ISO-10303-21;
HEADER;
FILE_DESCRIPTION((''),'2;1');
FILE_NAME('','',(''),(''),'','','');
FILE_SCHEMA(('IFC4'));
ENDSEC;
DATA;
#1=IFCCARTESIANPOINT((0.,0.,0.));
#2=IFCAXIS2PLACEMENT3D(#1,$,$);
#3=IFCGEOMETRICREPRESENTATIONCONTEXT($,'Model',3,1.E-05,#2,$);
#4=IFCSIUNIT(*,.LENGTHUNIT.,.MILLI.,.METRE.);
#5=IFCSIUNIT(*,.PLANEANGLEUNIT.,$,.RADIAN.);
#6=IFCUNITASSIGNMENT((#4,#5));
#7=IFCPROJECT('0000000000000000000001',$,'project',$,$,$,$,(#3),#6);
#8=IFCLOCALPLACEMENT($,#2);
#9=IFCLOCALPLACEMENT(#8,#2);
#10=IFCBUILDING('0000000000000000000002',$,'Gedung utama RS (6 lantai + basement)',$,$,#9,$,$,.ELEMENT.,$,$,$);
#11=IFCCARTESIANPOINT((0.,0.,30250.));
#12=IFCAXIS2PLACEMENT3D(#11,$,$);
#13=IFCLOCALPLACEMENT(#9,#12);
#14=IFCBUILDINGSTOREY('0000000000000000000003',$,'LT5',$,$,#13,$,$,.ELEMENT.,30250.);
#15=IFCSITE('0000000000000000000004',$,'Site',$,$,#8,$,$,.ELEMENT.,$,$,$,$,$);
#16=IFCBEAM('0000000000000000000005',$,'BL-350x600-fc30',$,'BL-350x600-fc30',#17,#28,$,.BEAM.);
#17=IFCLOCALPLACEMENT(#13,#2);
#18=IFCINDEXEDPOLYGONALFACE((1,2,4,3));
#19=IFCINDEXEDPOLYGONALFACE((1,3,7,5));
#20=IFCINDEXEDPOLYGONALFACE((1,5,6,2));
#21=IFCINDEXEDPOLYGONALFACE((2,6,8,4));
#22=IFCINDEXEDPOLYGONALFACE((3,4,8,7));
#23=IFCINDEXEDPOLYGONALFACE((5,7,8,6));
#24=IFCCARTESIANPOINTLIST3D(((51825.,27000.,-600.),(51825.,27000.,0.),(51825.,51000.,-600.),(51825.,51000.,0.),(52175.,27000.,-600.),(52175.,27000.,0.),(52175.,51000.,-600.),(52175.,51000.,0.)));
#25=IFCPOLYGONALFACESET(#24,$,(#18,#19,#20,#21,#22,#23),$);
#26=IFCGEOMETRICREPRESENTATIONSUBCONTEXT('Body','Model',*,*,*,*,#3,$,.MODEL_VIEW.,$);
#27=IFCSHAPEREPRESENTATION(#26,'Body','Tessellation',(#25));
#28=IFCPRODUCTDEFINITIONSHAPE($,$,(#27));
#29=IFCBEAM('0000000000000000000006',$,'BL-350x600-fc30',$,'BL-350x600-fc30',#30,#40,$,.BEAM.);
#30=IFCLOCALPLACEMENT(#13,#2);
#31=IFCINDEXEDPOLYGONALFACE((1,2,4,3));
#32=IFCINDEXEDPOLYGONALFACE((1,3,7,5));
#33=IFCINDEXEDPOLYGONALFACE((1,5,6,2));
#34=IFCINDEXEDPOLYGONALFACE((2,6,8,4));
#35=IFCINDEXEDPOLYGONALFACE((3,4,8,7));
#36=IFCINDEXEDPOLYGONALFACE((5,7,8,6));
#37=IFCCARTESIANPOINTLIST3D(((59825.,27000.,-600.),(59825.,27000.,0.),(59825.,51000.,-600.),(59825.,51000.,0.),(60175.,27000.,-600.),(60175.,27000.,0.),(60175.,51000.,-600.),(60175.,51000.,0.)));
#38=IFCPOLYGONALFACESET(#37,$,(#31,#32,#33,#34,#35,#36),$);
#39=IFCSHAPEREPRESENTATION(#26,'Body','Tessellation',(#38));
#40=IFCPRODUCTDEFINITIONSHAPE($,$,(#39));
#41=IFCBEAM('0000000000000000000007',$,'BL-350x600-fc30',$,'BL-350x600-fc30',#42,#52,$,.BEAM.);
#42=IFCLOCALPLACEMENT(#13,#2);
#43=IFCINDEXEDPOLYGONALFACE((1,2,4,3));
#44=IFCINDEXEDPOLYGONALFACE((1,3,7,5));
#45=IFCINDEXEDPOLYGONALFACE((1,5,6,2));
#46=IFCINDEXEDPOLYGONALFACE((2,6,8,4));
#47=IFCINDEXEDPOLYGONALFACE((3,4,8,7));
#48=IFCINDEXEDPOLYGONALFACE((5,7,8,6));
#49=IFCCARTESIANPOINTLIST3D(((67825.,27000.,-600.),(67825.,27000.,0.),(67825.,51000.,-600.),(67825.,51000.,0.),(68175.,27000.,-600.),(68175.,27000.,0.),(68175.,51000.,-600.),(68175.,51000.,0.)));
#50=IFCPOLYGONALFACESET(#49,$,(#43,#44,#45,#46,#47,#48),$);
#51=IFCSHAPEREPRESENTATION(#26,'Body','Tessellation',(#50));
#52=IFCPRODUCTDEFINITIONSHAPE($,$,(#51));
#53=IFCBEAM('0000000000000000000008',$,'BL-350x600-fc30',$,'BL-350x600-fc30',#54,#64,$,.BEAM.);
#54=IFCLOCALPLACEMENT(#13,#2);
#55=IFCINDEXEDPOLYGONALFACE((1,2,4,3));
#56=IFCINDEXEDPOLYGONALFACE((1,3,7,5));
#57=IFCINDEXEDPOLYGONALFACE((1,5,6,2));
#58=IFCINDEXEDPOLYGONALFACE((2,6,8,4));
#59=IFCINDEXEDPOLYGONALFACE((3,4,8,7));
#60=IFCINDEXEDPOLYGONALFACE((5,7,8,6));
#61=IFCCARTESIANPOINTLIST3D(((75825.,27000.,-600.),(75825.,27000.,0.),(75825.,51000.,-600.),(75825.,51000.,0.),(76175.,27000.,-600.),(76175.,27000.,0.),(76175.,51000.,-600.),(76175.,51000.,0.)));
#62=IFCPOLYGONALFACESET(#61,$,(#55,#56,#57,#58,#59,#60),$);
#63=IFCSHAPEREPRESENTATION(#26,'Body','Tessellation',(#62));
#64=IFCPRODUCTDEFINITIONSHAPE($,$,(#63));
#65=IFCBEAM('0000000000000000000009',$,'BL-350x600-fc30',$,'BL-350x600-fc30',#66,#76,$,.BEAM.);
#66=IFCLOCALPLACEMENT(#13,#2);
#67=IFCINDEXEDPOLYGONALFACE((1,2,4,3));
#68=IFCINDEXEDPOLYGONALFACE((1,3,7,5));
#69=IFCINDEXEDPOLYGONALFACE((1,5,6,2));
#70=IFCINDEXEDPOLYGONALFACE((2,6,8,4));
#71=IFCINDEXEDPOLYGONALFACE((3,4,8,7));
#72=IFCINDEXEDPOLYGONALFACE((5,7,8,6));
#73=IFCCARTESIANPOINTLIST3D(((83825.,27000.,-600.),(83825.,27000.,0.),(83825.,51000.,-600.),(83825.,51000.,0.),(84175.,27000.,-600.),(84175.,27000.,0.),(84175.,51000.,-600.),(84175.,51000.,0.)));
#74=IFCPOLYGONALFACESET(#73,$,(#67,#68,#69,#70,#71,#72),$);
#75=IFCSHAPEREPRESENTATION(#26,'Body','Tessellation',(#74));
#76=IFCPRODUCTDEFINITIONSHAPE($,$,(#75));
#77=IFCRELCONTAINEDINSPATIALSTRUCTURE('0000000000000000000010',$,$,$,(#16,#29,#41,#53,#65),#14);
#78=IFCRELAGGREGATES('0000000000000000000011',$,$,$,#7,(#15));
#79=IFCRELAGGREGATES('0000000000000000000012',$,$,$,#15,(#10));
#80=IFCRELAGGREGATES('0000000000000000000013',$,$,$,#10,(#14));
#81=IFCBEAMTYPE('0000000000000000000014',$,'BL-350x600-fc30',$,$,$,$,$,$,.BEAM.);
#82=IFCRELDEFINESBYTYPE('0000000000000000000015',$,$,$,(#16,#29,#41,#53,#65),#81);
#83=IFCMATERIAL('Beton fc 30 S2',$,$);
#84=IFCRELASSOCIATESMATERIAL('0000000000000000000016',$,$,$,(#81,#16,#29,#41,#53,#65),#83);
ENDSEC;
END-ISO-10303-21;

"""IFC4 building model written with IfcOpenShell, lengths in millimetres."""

from ifc_helpers import new_model, si_unit, frame, origin, origin_2d, place, context, subcontext, project, spatial, rectangle, extrude, material, material_profile, profile_set, profile_usage, type_object, element, save


model = new_model("IFC4")

# Units and contexts
model_context = context("Model", 3, precision=1e-05, world=origin())
body_context = subcontext(model_context, "Body", "Model", "MODEL_VIEW")
ifc_project = project(units=[si_unit("LENGTHUNIT", "METRE", prefix="MILLI"), si_unit("PLANEANGLEUNIT", "RADIAN")], contexts=[model_context])

# Site, building, storey
site_placement = place(None, origin())
site = spatial("IfcSite", under=ifc_project, at=site_placement, Name="Site", CompositionType="ELEMENT")
building_placement = place(site_placement, origin())
building = spatial("IfcBuilding", under=site, at=building_placement, Name="Gedung utama RS (6 lantai + basement)", CompositionType="ELEMENT")
storey_placement = place(building_placement, frame((0.0, 0.0, 30250.0)))
storey = spatial("IfcBuildingStorey", under=building, at=storey_placement, Name="LT5", CompositionType="ELEMENT", Elevation=30250.0)

# Beams
ifc_material = material(Name="Beton fc 30 S2")
ifc_material_profile_1 = material_profile(ifc_material, rectangle(XDim=350.0, YDim=600.0, at=origin_2d()), Name="BL-350x600-fc30")
ifc_profile_set_1 = profile_set([ifc_material_profile_1], Name="BL-350x600-fc30")
ifc_profile_usage_1 = profile_usage(ifc_profile_set_1, cardinal=8)
beam_type = type_object("IfcBeamType", Name="BL-350x600-fc30", PredefinedType="BEAM", material=ifc_profile_set_1)
for number, where, name in (
    (1, (52000.0, 27000.0, -300.0), "BL-350x600-fc30"),
    (2, (60000.0, 27000.0, -300.0), "BL-350x600-fc30"),
    (3, (68000.0, 27000.0, -300.0), "BL-350x600-fc30"),
    (4, (76000.0, 27000.0, -300.0), "BL-350x600-fc30"),
    (5, (84000.0, 27000.0, -300.0), "BL-350x600-fc30"),
):
    element("IfcBeam", number, at=place(storey_placement, frame(where)), inside=storey, type_object=beam_type, material=ifc_profile_usage_1, Name=name, ObjectType="BL-350x600-fc30", PredefinedType="BEAM", context=body_context, shape_type="SweptSolid", body=[
        extrude(rectangle(XDim=350.0, YDim=600.0, at=origin_2d()), frame((0.0, 0.0, 0.0), z_axis=(0.0, 1.0, 0.0), x_axis=(-1.0, 0.0, 0.0)), (0.0, 0.0, 1.0), 24000.0),
    ])

save(model, "model.ifc")
